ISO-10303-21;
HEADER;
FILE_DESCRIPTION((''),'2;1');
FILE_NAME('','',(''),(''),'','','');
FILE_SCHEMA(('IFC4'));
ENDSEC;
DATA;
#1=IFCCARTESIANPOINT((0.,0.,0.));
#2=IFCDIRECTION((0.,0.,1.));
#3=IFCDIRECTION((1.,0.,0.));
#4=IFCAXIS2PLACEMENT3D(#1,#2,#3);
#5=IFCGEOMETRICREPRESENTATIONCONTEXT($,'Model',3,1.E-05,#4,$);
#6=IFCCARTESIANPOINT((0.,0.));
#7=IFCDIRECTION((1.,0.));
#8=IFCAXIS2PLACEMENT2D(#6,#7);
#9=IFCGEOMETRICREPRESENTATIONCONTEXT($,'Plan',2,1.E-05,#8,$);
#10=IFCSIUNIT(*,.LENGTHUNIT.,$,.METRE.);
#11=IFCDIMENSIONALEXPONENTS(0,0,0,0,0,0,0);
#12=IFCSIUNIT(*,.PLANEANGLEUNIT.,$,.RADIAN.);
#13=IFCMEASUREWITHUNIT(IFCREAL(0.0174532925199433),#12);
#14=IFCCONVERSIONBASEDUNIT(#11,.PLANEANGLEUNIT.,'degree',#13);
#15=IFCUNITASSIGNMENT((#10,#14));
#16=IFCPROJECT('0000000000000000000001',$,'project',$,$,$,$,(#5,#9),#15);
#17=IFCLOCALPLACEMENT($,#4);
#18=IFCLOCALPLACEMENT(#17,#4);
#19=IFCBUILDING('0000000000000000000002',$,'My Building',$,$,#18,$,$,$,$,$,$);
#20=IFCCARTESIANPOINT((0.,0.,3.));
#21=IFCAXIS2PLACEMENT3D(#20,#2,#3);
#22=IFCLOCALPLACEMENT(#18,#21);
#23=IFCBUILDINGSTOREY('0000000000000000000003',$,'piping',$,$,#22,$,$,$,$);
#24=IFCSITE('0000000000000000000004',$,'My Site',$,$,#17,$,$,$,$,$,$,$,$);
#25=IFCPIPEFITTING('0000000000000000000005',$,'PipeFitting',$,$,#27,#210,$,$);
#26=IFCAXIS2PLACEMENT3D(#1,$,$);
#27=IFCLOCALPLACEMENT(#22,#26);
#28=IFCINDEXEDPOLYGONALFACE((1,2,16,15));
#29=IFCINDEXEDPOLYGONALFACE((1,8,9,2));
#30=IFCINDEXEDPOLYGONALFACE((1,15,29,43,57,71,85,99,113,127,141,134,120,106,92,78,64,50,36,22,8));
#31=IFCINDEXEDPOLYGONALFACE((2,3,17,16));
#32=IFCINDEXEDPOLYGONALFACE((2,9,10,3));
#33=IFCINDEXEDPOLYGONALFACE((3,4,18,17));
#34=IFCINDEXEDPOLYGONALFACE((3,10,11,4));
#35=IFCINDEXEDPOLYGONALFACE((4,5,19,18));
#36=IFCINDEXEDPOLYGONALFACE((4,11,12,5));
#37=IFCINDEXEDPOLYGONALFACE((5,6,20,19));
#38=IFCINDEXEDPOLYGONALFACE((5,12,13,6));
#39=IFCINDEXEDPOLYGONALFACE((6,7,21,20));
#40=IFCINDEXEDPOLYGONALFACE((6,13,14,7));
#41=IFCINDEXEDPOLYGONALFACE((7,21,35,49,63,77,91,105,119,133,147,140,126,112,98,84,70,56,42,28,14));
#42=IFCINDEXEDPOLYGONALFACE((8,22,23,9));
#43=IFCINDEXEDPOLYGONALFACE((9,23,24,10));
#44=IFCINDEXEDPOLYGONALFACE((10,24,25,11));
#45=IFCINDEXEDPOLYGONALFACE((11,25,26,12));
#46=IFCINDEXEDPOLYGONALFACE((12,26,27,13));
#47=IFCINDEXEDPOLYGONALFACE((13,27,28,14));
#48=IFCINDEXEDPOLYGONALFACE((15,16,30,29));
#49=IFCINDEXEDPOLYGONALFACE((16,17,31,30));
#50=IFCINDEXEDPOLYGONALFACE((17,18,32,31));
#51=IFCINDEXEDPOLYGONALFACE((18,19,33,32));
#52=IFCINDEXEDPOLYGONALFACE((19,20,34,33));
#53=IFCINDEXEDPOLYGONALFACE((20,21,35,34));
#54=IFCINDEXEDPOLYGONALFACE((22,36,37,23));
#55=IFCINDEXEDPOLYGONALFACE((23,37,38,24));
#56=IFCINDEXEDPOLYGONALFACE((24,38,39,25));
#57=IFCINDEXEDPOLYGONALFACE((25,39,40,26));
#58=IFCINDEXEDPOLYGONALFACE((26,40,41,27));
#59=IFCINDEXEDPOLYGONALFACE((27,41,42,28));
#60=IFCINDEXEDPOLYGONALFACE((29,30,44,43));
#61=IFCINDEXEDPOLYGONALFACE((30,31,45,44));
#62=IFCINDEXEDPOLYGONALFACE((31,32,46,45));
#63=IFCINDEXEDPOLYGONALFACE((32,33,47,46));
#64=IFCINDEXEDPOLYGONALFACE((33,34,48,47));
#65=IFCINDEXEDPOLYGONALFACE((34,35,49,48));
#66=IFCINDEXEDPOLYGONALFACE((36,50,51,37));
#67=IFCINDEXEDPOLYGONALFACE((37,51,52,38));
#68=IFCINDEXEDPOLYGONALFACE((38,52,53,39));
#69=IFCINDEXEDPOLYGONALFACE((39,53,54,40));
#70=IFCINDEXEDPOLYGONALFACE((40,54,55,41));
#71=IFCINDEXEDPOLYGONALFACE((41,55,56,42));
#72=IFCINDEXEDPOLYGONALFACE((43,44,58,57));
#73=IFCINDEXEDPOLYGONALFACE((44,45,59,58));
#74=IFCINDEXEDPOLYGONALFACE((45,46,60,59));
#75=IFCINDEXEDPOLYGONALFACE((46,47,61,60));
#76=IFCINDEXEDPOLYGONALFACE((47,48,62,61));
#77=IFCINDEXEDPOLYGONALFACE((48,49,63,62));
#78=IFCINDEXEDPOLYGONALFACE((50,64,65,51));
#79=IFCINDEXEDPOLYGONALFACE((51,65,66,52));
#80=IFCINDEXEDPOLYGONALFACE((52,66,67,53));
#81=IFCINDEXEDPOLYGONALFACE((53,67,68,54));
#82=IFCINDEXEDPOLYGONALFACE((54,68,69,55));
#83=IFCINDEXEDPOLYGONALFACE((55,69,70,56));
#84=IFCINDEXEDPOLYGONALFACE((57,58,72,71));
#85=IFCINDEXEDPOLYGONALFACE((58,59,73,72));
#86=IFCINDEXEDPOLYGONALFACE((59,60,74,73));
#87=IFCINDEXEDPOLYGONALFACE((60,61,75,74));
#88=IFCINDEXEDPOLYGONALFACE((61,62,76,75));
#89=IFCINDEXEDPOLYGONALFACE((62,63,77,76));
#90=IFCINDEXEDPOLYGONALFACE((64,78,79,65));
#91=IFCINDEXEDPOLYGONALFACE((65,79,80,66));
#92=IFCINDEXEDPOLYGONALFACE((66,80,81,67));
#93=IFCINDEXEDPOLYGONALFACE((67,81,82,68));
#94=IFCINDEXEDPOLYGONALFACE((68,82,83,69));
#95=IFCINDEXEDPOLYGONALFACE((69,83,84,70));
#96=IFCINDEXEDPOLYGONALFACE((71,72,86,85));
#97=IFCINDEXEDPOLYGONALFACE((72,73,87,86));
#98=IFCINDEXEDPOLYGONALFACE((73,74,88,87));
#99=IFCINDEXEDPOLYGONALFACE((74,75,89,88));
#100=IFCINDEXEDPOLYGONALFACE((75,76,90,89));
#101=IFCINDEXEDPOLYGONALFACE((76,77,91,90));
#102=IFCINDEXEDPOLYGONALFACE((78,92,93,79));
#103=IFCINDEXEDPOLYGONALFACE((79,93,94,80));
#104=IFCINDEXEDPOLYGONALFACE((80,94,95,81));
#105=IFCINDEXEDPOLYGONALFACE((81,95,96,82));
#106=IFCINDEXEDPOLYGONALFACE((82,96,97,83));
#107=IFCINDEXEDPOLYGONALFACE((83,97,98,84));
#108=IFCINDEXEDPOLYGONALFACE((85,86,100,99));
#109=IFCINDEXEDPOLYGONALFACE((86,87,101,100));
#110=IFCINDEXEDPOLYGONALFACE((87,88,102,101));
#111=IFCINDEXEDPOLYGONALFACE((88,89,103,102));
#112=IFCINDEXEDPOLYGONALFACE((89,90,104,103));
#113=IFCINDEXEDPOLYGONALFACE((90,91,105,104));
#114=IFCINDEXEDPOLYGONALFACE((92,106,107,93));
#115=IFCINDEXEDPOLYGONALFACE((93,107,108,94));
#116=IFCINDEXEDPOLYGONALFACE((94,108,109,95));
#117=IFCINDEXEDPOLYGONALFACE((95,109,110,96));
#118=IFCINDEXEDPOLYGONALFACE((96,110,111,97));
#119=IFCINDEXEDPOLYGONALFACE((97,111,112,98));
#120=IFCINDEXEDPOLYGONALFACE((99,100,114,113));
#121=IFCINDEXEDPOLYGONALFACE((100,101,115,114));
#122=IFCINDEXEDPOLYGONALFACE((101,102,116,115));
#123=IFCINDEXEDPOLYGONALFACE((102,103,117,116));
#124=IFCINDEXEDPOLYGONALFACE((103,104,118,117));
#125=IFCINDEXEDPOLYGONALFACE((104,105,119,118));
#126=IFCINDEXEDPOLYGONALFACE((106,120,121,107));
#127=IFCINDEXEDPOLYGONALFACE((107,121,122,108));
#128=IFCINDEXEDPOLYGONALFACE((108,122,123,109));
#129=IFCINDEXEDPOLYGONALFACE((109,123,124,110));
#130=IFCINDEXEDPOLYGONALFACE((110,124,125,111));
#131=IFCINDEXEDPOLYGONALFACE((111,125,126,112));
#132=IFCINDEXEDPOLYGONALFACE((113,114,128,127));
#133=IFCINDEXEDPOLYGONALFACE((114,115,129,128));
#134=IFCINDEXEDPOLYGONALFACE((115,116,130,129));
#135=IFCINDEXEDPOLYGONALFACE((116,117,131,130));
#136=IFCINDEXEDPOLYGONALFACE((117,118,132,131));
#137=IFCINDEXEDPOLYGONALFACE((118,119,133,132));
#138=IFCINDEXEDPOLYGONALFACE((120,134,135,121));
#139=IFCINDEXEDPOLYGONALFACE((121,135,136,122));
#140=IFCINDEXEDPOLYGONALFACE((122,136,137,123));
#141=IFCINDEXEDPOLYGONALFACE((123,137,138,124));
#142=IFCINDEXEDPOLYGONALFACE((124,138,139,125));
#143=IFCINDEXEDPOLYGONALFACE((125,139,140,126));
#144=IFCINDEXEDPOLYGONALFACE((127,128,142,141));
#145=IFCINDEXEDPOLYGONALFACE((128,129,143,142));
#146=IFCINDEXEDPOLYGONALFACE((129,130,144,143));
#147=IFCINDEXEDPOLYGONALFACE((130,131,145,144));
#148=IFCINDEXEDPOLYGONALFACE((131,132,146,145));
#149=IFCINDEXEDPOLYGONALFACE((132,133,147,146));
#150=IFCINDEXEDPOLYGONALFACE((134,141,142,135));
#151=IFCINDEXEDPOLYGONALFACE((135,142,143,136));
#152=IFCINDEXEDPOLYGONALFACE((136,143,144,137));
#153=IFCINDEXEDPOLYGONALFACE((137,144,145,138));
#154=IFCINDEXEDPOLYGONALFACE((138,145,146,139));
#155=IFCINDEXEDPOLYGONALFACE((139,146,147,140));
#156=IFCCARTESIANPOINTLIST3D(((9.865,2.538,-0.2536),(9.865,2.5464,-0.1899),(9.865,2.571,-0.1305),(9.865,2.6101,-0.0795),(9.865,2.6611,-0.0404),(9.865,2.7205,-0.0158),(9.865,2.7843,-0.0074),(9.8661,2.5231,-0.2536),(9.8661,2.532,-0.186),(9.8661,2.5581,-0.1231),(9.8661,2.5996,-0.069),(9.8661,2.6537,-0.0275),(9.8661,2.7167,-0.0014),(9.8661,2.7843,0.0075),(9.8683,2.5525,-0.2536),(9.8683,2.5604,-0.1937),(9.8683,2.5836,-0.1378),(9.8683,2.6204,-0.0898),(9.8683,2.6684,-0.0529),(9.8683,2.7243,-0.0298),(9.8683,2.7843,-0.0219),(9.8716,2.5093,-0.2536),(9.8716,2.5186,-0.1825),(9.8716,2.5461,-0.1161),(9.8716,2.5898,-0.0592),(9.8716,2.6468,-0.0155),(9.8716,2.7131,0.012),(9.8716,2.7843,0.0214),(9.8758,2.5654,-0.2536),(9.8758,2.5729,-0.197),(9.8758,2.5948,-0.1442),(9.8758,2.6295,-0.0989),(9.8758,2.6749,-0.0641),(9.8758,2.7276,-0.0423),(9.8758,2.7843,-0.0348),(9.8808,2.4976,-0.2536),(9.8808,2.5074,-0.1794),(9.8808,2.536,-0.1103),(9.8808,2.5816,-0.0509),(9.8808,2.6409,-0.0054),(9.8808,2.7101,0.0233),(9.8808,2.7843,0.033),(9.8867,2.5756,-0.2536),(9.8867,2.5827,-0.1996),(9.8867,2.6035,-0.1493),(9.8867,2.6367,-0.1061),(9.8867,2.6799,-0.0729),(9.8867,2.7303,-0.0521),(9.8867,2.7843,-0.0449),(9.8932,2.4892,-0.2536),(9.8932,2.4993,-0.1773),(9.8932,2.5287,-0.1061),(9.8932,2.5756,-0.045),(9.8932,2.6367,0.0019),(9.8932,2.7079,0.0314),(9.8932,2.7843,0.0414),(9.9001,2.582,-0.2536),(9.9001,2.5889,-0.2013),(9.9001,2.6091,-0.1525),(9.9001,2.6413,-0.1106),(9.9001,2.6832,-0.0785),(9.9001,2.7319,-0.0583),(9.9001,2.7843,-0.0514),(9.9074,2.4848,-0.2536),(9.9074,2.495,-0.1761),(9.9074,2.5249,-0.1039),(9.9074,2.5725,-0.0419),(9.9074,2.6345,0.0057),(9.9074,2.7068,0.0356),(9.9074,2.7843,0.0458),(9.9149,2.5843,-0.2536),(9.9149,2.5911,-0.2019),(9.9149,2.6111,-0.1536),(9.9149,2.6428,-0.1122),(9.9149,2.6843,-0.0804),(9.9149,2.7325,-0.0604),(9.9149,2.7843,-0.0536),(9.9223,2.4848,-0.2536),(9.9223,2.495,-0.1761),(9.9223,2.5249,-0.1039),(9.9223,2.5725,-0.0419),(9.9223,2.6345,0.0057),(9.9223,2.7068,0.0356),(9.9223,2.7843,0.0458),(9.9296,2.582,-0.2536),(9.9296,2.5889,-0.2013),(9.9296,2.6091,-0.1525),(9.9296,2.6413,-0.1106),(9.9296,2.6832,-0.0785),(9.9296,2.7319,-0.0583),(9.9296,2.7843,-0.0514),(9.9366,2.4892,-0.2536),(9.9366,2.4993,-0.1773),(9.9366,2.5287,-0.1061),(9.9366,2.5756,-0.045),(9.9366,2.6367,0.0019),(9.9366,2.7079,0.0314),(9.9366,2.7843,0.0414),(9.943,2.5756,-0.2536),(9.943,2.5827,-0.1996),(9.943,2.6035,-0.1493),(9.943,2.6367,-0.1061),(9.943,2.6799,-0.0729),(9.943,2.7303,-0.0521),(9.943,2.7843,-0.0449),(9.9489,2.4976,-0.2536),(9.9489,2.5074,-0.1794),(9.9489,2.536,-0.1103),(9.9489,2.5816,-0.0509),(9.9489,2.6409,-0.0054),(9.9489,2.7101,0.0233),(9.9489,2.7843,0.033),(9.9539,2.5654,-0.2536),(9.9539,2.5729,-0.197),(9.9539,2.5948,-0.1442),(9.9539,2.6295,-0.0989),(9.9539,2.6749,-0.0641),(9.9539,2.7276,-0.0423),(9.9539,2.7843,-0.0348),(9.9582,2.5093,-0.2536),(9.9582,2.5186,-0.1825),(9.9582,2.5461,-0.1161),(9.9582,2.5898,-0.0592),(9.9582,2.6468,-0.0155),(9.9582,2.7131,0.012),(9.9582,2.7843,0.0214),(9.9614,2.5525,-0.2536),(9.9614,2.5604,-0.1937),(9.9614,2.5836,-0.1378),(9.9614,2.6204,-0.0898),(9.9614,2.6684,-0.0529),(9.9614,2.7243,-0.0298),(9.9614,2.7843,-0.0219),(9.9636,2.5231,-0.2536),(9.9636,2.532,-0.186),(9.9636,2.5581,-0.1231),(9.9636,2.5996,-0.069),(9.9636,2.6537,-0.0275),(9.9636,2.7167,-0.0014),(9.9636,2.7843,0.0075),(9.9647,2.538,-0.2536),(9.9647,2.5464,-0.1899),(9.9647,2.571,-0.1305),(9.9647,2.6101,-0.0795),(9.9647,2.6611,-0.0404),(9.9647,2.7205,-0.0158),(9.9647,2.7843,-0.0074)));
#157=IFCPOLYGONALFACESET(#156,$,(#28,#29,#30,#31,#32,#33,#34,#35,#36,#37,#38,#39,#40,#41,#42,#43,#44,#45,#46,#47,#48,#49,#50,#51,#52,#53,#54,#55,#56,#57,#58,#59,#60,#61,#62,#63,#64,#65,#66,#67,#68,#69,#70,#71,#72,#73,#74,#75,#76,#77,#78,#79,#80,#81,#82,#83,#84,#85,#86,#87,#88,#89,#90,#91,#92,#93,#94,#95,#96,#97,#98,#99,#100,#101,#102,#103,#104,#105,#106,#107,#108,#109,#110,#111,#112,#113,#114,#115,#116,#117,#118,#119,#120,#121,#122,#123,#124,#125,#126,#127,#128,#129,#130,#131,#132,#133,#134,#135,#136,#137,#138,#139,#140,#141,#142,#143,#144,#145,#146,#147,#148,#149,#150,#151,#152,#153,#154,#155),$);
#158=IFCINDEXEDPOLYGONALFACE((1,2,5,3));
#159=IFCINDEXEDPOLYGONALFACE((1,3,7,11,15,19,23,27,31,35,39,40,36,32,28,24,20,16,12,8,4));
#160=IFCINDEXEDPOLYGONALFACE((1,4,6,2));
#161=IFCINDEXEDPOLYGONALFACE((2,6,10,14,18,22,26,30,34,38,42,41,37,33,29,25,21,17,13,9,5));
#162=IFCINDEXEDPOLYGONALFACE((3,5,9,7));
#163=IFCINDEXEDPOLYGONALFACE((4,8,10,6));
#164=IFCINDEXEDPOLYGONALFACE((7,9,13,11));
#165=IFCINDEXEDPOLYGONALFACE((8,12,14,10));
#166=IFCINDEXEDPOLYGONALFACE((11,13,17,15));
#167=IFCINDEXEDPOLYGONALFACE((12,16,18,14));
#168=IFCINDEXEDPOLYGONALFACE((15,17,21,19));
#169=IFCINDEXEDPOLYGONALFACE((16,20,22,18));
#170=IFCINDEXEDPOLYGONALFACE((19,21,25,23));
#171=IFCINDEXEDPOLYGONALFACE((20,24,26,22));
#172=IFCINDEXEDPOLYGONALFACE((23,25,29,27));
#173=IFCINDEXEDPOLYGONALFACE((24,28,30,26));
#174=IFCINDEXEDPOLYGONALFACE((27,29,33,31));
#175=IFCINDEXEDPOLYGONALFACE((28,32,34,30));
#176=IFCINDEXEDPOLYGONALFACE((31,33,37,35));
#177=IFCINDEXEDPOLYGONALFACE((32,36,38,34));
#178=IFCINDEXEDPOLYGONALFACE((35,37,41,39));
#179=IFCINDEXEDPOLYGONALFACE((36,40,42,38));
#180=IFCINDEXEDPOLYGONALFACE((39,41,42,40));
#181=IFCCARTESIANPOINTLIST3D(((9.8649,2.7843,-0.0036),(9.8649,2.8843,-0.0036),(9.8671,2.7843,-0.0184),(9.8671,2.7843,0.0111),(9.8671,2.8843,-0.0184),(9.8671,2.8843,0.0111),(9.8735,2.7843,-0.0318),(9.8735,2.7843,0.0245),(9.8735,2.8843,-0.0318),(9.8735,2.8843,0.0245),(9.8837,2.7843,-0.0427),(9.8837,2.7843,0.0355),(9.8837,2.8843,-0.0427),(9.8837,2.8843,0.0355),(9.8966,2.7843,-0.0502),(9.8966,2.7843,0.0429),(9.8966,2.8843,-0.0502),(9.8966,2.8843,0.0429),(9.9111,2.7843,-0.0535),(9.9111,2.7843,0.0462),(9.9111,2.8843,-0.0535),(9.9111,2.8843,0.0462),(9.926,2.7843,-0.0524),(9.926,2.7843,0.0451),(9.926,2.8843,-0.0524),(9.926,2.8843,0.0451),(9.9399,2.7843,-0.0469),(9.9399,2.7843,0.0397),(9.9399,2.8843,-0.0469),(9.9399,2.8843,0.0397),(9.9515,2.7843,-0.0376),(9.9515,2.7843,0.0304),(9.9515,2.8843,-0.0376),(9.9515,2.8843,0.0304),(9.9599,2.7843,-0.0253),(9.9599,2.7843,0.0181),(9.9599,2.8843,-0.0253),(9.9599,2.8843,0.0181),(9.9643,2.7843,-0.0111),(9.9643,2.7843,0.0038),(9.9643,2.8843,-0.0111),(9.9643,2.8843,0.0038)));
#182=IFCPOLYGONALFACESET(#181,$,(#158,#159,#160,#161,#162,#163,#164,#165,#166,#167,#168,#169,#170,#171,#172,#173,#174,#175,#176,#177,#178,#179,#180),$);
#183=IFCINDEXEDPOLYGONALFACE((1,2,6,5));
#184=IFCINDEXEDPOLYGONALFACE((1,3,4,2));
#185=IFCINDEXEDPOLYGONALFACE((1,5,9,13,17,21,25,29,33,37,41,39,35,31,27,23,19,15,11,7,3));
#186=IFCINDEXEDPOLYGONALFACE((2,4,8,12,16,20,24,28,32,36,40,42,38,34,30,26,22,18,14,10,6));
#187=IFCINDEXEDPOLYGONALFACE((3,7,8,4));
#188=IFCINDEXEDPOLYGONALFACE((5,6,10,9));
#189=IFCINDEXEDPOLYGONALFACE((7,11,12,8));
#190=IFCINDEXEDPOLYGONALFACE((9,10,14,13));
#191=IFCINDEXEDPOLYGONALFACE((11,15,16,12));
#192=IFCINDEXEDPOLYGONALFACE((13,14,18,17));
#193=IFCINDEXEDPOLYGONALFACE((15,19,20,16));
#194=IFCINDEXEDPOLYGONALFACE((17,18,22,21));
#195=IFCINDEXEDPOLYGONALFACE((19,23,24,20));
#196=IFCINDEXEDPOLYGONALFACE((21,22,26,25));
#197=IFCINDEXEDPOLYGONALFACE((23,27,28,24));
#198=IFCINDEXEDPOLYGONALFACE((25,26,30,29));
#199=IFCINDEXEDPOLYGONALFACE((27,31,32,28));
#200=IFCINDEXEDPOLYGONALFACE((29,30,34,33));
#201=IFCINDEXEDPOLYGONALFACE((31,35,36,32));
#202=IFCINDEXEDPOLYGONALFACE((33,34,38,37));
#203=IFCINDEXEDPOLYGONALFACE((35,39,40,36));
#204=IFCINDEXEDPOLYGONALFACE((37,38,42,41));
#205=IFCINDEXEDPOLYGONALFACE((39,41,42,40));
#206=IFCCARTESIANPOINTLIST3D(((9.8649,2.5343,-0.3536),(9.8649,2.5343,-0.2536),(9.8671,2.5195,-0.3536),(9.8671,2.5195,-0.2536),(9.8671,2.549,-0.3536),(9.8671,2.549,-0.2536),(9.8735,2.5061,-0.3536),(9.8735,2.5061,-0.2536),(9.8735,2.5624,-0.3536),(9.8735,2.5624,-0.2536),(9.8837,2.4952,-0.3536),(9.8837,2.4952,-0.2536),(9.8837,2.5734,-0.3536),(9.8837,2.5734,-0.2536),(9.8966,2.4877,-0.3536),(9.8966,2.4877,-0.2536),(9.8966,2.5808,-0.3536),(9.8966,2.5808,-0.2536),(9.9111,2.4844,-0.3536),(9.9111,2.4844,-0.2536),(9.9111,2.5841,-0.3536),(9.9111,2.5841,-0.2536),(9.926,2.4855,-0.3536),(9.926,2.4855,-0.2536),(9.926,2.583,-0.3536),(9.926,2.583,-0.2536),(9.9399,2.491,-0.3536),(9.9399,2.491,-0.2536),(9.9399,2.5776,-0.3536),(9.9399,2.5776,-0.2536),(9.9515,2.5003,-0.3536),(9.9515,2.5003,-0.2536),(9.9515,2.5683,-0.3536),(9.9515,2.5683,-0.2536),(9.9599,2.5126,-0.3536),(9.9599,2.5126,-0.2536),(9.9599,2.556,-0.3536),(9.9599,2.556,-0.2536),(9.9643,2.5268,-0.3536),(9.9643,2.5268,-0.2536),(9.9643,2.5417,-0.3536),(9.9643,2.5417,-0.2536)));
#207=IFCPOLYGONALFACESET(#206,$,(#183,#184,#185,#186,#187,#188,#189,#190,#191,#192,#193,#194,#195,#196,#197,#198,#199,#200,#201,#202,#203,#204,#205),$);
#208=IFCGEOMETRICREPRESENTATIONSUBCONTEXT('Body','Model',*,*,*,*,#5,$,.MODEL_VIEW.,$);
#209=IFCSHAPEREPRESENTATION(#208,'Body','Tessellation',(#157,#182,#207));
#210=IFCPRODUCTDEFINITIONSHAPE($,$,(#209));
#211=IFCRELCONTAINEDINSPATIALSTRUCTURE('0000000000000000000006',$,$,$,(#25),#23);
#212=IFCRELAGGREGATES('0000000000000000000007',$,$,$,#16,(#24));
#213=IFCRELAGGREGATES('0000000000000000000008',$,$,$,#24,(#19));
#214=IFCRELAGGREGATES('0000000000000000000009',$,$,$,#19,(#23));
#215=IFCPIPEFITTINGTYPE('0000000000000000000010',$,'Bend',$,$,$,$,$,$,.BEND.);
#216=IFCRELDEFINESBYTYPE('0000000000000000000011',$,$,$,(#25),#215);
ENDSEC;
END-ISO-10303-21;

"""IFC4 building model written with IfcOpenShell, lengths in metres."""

from ifc_helpers import new_model, entity, si_unit, converted_unit, frame, origin_with_axes, origin_2d_with_axis, place, context, subcontext, project, spatial, circle, extrude, source, transform, mapped, type_object, type_shapes, element, save


model = new_model("IFC4")

# Units and contexts
model_context = context("Model", 3, precision=1e-05, world=origin_with_axes())
plan_context = context("Plan", 2, precision=1e-05, world=origin_2d_with_axis())
body_context = subcontext(model_context, "Body", "Model", "MODEL_VIEW")
ifc_project = project(units=[si_unit("LENGTHUNIT", "METRE"), converted_unit("PLANEANGLEUNIT", "degree", entity("IfcReal", 0.0174532925199433), si_unit("PLANEANGLEUNIT", "RADIAN"), dimensions=[0, 0, 0, 0, 0, 0, 0])], contexts=[model_context, plan_context])

# Site, building, storey
site_placement = place(None, origin_with_axes())
site = spatial("IfcSite", under=ifc_project, at=site_placement, Name="My Site")
building_placement = place(site_placement, origin_with_axes())
building = spatial("IfcBuilding", under=site, at=building_placement, Name="My Building")
storey_placement = place(building_placement, frame((0.0, 0.0, 3.0), z_axis=(0.0, 0.0, 1.0), x_axis=(1.0, 0.0, 0.0)))
storey = spatial("IfcBuildingStorey", under=building, at=storey_placement, Name="piping")

# Pipe fitting
pipe_fitting_type = type_object("IfcPipeFittingType", Name="Bend", PredefinedType="BEND")
shared_shape = source(origin_with_axes(), body_context, "Body", "SolidModel", [
    entity("IfcSweptDiskSolid", entity("IfcIndexedPolyCurve", entity("IfcCartesianPointList3D", [[0.0, 0.0, -0.1], [0.0, -0.0732, -0.2768], [0.0, -0.25, -0.35]]), [entity("IfcArcIndex", [1, 2, 3])]), 0.05),
    extrude(circle(Radius=0.05), origin_with_axes(), (0.0, 0.0, -1.0), 0.1),
    extrude(circle(Radius=0.05), frame((0.0, -0.25, -0.35), z_axis=(0.0, -1.0, 0.0), x_axis=(1.0, 0.0, 0.0)), (0.0, 0.0, 1.0), 0.1),
])
type_shapes(pipe_fitting_type, [shared_shape])
for number, where, z_axis, x_axis, name in (
    (1, (9.9149, 2.8843, -0.0036), (0.0, 1.0, 0.0), (-1.0, 0.0, 0.0), "PipeFitting"),
):
    element("IfcPipeFitting", number, at=place(storey_placement, frame(where, z_axis=z_axis, x_axis=x_axis)), inside=storey, type_object=pipe_fitting_type, Name=name, context=body_context, shape_type="MappedRepresentation", body=[
        mapped(shared_shape, transform((0.0, 0.0, 0.0), x_axis=(1.0, 0.0, 0.0), y_axis=(0.0, 1.0, 0.0), z_axis=(0.0, 0.0, 1.0), scale=1.0)),
    ])

save(model, "model.ifc")
